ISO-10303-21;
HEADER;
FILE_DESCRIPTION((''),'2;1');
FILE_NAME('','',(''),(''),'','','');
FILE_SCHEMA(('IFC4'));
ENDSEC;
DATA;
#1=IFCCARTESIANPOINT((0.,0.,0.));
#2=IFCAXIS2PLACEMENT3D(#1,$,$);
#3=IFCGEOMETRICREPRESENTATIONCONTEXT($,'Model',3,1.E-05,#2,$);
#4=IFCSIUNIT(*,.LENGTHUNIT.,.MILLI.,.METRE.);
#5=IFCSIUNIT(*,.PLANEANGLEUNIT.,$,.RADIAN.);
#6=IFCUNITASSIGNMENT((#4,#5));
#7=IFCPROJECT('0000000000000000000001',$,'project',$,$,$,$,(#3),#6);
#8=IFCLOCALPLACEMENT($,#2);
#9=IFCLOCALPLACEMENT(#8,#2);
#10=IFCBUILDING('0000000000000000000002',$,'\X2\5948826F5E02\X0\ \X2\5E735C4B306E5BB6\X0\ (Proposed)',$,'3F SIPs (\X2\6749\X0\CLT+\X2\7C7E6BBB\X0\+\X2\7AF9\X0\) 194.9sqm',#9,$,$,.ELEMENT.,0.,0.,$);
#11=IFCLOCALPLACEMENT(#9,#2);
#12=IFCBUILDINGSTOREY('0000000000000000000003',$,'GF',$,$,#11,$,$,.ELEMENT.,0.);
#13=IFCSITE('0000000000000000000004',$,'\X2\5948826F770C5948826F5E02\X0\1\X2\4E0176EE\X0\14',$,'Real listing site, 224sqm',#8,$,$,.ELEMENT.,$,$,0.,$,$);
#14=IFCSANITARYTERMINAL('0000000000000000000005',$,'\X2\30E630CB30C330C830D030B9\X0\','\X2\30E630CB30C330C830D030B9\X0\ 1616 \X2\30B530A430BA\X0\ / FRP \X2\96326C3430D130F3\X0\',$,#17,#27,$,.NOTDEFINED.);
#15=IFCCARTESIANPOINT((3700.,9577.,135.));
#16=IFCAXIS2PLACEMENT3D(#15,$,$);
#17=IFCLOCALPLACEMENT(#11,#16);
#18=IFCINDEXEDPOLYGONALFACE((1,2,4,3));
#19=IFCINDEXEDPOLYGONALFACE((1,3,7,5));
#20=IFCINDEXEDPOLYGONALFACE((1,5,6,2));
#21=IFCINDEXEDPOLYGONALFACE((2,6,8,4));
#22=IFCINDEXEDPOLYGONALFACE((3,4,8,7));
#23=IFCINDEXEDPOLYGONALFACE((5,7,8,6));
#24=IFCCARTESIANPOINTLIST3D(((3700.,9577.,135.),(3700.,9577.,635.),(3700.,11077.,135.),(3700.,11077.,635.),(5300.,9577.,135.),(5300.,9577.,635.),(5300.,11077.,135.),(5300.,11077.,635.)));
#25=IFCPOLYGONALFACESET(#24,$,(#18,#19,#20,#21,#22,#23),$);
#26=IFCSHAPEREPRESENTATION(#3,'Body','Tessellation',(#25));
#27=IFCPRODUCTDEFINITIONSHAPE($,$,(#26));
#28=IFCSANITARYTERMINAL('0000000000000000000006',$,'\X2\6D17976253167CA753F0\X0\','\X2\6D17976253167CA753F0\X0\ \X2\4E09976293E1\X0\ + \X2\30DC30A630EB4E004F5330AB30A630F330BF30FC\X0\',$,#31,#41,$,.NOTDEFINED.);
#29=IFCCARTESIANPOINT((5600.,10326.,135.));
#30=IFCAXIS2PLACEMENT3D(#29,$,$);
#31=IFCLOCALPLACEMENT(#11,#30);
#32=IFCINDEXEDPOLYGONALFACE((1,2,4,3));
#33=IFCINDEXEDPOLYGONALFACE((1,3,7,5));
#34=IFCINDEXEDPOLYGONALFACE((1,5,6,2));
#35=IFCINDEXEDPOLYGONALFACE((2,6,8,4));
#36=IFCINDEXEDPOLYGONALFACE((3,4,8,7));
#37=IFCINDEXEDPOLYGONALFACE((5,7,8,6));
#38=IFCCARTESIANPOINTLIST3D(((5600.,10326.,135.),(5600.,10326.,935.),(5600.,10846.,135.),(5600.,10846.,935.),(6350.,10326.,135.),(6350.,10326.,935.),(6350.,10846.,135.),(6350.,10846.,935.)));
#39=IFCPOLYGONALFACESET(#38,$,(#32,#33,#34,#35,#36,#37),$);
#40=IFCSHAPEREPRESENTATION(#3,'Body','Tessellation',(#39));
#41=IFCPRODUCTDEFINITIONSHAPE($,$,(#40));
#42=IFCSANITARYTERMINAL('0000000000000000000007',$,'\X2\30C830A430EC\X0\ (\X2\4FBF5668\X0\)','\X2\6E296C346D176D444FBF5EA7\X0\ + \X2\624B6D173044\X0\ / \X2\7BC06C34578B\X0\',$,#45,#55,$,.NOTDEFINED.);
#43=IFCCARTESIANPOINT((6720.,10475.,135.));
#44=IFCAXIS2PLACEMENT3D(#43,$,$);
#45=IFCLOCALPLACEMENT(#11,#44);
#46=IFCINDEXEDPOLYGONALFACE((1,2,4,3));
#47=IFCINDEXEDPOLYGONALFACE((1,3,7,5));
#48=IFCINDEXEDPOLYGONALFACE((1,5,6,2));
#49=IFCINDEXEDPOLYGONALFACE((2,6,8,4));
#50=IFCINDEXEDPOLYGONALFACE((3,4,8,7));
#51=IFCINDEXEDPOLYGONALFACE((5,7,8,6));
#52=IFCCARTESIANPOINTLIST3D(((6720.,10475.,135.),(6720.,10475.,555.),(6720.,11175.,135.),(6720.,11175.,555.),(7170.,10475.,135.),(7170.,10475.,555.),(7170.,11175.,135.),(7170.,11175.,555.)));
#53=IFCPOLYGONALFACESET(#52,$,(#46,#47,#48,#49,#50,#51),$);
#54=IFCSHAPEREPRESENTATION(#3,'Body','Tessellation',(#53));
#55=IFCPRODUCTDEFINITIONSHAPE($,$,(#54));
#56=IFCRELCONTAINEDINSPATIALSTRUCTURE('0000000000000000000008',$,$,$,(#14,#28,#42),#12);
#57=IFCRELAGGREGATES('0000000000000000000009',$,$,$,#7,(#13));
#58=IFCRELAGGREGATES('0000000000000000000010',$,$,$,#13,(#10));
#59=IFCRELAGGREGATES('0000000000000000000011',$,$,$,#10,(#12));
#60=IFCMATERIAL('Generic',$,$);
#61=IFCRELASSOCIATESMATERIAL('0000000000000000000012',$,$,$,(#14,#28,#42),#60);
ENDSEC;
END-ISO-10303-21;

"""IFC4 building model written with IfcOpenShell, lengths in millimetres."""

from ifc_helpers import new_model, si_unit, frame, frame_2d, origin, place, context, project, spatial, rectangle, extrude, material, element, save


model = new_model("IFC4")

# Units and contexts
model_context = context("Model", 3, precision=1e-05, world=origin())
ifc_project = project(units=[si_unit("LENGTHUNIT", "METRE", prefix="MILLI"), si_unit("PLANEANGLEUNIT", "RADIAN")], contexts=[model_context])

# Site, building, storey
site_placement = place(None, origin())
site = spatial("IfcSite", under=ifc_project, at=site_placement, Name="奈良県奈良市1丁目14", ObjectType="Real listing site, 224sqm", CompositionType="ELEMENT", RefElevation=0.0)
building_placement = place(site_placement, origin())
building = spatial("IfcBuilding", under=site, at=building_placement, Name="奈良市 平屋の家 (Proposed)", ObjectType="3F SIPs (杉CLT+籾殻+竹) 194.9sqm", CompositionType="ELEMENT", ElevationOfRefHeight=0.0, ElevationOfTerrain=0.0)
storey_placement = place(building_placement, origin())
storey = spatial("IfcBuildingStorey", under=building, at=storey_placement, Name="GF", CompositionType="ELEMENT", Elevation=0.0)

# Shared definitions
ifc_material_1 = material(Name="Generic")

# Sanitary terminals
sanitary_terminal_1_placement = place(storey_placement, frame((3700.0, 9577.0, 135.0)))
element("IfcSanitaryTerminal", 1, at=sanitary_terminal_1_placement, inside=storey, material=ifc_material_1, Name="ユニットバス", Description="ユニットバス 1616 サイズ / FRP 防水パン", PredefinedType="NOTDEFINED", context=model_context, shape_type="SweptSolid", body=[
    extrude(rectangle(XDim=1600.0, YDim=1500.0, at=frame_2d((800.0, 750.0))), frame((3700.0, 9577.0, 135.0)), (0.0, 0.0, 1.0), 500.0),
])
sanitary_terminal_2_placement = place(storey_placement, frame((5600.0, 10326.0, 135.0)))
element("IfcSanitaryTerminal", 2, at=sanitary_terminal_2_placement, inside=storey, material=ifc_material_1, Name="洗面化粧台", Description="洗面化粧台 三面鏡 + ボウル一体カウンター", PredefinedType="NOTDEFINED", context=model_context, shape_type="SweptSolid", body=[
    extrude(rectangle(XDim=750.0, YDim=520.0, at=frame_2d((375.0, 260.0))), frame((5600.0, 10326.0, 135.0)), (0.0, 0.0, 1.0), 800.0),
])
sanitary_terminal_3_placement = place(storey_placement, frame((6720.0, 10475.0, 135.0)))
element("IfcSanitaryTerminal", 3, at=sanitary_terminal_3_placement, inside=storey, material=ifc_material_1, Name="トイレ (便器)", Description="温水洗浄便座 + 手洗い / 節水型", PredefinedType="NOTDEFINED", context=model_context, shape_type="SweptSolid", body=[
    extrude(rectangle(XDim=450.0, YDim=700.0, at=frame_2d((225.0, 350.0))), frame((6720.0, 10475.0, 135.0)), (0.0, 0.0, 1.0), 420.0),
])

save(model, "model.ifc")
